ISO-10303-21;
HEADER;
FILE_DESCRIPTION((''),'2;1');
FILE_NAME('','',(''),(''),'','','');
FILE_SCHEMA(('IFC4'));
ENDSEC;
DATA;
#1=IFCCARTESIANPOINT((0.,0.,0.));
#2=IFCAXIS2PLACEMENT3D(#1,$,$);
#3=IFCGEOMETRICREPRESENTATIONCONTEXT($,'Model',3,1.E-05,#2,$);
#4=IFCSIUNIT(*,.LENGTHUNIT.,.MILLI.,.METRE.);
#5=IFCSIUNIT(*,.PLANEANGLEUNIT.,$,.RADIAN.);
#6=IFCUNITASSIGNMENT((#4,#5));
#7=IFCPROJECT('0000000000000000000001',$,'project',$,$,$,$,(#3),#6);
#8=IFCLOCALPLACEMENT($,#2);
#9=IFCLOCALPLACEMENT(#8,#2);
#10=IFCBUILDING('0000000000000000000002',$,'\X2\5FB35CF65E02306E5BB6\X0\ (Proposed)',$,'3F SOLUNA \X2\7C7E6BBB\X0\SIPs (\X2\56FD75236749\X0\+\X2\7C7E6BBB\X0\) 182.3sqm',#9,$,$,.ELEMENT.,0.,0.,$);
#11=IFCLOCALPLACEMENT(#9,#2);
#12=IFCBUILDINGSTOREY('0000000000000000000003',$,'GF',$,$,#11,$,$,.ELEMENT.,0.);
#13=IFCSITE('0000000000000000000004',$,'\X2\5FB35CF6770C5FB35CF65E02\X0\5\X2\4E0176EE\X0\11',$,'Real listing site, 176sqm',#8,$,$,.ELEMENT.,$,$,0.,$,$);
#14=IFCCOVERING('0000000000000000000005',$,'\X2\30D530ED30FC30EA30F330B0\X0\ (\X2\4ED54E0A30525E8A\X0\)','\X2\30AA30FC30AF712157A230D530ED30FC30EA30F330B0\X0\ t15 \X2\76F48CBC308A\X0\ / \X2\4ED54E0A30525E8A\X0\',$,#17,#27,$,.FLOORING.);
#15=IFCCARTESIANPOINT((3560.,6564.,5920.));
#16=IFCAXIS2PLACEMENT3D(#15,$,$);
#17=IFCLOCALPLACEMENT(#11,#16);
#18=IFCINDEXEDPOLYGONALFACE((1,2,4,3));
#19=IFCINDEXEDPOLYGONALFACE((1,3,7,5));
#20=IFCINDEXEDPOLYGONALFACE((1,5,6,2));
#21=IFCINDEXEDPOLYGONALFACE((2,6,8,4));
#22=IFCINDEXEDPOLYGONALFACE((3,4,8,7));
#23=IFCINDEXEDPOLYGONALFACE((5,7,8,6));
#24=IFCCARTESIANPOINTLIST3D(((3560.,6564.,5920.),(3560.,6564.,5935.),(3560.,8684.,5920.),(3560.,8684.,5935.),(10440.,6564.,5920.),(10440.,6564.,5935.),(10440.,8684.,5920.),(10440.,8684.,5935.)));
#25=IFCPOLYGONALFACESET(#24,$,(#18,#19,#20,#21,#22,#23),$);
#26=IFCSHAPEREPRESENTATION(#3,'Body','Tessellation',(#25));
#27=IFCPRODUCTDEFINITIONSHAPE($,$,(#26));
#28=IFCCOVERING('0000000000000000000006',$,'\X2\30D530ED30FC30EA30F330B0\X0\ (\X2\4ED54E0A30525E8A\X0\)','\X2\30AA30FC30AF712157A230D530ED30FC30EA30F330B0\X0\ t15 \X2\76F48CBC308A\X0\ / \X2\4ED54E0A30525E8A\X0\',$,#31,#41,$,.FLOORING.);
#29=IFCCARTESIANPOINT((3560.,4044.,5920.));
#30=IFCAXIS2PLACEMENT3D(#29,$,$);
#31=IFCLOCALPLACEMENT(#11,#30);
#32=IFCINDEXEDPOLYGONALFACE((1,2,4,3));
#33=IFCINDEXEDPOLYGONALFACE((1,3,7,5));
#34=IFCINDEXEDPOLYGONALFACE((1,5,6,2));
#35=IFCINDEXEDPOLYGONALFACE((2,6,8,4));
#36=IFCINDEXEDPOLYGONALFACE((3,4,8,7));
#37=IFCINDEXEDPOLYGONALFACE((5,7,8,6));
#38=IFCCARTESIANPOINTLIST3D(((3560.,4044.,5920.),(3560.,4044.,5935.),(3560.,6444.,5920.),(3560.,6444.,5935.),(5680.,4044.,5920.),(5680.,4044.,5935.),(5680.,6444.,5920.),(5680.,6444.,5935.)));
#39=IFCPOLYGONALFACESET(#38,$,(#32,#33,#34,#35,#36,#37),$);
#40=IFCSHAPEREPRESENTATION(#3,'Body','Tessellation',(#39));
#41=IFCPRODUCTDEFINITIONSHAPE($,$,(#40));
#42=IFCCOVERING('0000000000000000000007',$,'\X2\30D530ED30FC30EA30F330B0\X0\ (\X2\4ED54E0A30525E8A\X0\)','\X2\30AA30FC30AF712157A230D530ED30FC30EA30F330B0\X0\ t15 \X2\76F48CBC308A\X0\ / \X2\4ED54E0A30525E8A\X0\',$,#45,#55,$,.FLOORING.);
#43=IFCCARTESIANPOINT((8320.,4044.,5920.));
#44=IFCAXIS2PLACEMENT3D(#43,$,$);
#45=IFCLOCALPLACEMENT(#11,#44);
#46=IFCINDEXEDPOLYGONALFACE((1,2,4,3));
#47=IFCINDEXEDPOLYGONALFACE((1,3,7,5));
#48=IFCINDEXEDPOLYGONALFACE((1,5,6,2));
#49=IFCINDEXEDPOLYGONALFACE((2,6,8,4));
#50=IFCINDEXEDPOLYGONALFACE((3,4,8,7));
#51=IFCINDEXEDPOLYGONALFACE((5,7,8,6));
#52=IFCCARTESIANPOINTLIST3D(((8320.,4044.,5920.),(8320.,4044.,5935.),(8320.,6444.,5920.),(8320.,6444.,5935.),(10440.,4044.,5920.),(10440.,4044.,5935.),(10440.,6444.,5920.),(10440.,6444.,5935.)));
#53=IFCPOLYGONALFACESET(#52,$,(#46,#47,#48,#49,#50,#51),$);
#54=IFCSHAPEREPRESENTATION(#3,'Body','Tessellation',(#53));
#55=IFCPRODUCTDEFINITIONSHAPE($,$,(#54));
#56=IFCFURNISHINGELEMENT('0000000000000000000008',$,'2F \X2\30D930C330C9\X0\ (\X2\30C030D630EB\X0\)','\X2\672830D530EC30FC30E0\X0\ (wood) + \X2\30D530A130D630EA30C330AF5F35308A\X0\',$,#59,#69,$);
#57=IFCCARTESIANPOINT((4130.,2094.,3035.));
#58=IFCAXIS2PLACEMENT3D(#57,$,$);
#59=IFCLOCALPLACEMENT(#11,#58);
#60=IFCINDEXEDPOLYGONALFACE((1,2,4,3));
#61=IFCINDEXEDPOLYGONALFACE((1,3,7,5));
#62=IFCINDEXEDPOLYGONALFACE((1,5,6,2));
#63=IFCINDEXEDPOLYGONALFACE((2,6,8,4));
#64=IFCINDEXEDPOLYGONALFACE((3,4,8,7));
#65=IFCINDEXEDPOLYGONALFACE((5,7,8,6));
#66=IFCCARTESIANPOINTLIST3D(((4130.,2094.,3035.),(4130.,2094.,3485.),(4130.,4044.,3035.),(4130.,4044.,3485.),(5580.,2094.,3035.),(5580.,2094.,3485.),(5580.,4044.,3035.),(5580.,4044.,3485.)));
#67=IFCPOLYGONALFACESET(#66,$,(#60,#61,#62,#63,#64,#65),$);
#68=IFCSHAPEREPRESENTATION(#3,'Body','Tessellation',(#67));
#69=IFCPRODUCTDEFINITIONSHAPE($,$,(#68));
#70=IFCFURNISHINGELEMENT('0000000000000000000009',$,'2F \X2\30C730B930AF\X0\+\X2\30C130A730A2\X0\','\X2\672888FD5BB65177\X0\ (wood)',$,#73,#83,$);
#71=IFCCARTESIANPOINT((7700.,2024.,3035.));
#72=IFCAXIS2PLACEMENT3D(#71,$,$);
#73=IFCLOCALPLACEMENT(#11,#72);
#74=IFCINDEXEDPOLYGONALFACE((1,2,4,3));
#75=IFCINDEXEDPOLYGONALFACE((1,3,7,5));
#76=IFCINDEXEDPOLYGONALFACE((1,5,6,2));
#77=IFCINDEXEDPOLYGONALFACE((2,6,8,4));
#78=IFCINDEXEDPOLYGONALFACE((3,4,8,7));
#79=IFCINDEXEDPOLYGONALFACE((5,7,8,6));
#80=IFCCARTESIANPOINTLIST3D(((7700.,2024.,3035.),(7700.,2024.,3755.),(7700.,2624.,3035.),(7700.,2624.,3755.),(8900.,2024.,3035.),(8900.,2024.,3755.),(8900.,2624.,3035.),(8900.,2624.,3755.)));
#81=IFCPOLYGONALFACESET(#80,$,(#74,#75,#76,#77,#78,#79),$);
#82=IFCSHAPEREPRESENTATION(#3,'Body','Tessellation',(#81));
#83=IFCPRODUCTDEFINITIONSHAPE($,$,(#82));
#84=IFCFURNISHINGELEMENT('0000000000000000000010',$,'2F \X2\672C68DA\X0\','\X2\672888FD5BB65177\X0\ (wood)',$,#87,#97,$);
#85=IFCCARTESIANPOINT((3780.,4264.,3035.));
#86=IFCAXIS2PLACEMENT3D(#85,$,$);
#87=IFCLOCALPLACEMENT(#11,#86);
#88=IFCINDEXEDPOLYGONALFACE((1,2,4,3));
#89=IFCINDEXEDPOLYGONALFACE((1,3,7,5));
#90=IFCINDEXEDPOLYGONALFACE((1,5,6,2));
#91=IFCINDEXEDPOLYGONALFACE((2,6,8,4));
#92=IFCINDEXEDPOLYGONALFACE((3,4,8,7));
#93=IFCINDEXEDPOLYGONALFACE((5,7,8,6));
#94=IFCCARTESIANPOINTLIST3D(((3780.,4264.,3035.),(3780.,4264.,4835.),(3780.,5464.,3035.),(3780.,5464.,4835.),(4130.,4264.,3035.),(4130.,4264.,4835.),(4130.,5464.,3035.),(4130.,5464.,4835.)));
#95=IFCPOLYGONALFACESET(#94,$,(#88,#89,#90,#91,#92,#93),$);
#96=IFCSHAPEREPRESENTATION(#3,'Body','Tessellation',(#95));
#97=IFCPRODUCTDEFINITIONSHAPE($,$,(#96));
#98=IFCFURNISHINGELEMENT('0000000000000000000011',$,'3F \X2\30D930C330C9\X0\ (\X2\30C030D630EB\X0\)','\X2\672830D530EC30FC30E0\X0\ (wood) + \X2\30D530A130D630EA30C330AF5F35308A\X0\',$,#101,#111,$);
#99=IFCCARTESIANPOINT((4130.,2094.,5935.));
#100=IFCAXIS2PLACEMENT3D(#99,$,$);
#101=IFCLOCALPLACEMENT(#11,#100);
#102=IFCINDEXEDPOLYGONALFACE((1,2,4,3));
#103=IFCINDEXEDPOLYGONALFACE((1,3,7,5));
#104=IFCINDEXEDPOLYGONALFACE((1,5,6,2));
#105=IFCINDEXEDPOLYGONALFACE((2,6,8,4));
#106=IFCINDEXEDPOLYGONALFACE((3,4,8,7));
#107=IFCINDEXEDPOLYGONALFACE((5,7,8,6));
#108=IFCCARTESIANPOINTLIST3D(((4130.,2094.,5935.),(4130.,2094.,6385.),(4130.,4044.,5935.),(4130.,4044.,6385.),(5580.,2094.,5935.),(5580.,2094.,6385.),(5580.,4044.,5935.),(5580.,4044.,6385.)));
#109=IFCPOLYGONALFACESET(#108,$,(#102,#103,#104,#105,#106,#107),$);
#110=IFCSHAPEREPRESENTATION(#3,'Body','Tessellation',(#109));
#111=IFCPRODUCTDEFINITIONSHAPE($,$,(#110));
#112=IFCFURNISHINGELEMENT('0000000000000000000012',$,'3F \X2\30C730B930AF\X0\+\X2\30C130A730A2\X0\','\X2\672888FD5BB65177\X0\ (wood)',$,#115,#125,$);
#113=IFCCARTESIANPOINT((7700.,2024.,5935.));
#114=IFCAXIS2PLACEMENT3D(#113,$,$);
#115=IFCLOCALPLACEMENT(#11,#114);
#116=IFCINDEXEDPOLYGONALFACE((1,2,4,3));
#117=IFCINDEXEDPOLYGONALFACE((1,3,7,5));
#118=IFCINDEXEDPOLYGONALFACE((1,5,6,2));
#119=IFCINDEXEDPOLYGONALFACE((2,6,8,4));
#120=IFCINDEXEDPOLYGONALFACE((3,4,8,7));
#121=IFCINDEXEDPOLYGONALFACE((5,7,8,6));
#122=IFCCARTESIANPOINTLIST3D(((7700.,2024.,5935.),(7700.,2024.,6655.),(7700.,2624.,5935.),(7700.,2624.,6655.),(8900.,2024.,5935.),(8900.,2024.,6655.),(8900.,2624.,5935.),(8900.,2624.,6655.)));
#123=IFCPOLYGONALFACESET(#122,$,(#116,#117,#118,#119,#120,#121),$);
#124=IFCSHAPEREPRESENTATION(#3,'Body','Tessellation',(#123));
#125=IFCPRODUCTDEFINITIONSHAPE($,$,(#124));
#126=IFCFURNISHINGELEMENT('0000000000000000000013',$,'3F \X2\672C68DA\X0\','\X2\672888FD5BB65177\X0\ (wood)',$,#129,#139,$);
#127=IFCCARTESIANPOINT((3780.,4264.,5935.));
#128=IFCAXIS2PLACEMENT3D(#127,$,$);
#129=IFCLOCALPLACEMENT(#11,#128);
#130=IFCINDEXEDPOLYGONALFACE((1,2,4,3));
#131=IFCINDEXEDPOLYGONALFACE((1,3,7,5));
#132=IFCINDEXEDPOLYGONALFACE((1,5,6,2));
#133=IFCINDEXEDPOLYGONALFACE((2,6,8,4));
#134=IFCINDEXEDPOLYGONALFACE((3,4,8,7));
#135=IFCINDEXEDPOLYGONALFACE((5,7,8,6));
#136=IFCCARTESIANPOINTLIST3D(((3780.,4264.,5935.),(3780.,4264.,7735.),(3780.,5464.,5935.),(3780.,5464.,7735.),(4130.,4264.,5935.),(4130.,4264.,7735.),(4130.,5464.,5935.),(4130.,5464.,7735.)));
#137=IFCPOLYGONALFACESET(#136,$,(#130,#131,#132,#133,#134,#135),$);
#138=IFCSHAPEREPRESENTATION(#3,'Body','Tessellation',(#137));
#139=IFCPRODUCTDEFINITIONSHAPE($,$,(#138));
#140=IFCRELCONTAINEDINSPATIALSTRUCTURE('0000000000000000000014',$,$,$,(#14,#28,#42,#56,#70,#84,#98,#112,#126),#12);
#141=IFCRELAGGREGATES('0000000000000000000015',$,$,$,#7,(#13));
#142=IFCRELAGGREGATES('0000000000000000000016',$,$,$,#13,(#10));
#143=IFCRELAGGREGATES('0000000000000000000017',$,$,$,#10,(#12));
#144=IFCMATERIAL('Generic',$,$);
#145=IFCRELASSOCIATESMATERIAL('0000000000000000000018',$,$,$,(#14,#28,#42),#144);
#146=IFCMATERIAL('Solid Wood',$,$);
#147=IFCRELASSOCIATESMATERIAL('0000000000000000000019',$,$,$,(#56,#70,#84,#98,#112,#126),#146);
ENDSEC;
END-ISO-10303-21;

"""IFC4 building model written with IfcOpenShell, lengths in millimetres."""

from ifc_helpers import new_model, si_unit, frame, frame_2d, origin, place, context, project, spatial, rectangle, extrude, material, element, save


model = new_model("IFC4")

# Units and contexts
model_context = context("Model", 3, precision=1e-05, world=origin())
ifc_project = project(units=[si_unit("LENGTHUNIT", "METRE", prefix="MILLI"), si_unit("PLANEANGLEUNIT", "RADIAN")], contexts=[model_context])

# Site, building, storey
site_placement = place(None, origin())
site = spatial("IfcSite", under=ifc_project, at=site_placement, Name="徳島県徳島市5丁目11", ObjectType="Real listing site, 176sqm", CompositionType="ELEMENT", RefElevation=0.0)
building_placement = place(site_placement, origin())
building = spatial("IfcBuilding", under=site, at=building_placement, Name="徳島市の家 (Proposed)", ObjectType="3F SOLUNA 籾殻SIPs (国産杉+籾殻) 182.3sqm", CompositionType="ELEMENT", ElevationOfRefHeight=0.0, ElevationOfTerrain=0.0)
storey_placement = place(building_placement, origin())
storey = spatial("IfcBuildingStorey", under=building, at=storey_placement, Name="GF", CompositionType="ELEMENT", Elevation=0.0)

# Shared definitions
ifc_material_1 = material(Name="Solid Wood")

# Shared definitions
ifc_material_2 = material(Name="Generic")

# Coverings
covering_1_placement = place(storey_placement, frame((3560.0, 6564.0, 5920.0)))
element("IfcCovering", 1, at=covering_1_placement, inside=storey, material=ifc_material_2, Name="フローリング (仕上げ床)", Description="オーク無垢フローリング t15 直貼り / 仕上げ床", PredefinedType="FLOORING", context=model_context, shape_type="SweptSolid", body=[
    extrude(rectangle(XDim=6880.0, YDim=2120.0, at=frame_2d((3440.0, 1060.0))), frame((3560.0, 6564.0, 5920.0)), (0.0, 0.0, 1.0), 15.0),
])
covering_2_placement = place(storey_placement, frame((3560.0, 4044.0, 5920.0)))
element("IfcCovering", 2, at=covering_2_placement, inside=storey, material=ifc_material_2, Name="フローリング (仕上げ床)", Description="オーク無垢フローリング t15 直貼り / 仕上げ床", PredefinedType="FLOORING", context=model_context, shape_type="SweptSolid", body=[
    extrude(rectangle(XDim=2120.0, YDim=2400.0, at=frame_2d((1060.0, 1200.0))), frame((3560.0, 4044.0, 5920.0)), (0.0, 0.0, 1.0), 15.0),
])
covering_3_placement = place(storey_placement, frame((8320.0, 4044.0, 5920.0)))
element("IfcCovering", 3, at=covering_3_placement, inside=storey, material=ifc_material_2, Name="フローリング (仕上げ床)", Description="オーク無垢フローリング t15 直貼り / 仕上げ床", PredefinedType="FLOORING", context=model_context, shape_type="SweptSolid", body=[
    extrude(rectangle(XDim=2120.0, YDim=2400.0, at=frame_2d((1060.0, 1200.0))), frame((8320.0, 4044.0, 5920.0)), (0.0, 0.0, 1.0), 15.0),
])

# Furnishing elements
furnishing_1_placement = place(storey_placement, frame((4130.0, 2094.0, 3035.0)))
element("IfcFurnishingElement", 4, at=furnishing_1_placement, inside=storey, material=ifc_material_1, Name="2F ベッド (ダブル)", Description="木フレーム (wood) + ファブリック張り", context=model_context, shape_type="SweptSolid", body=[
    extrude(rectangle(XDim=1450.0, YDim=1950.0, at=frame_2d((725.0, 975.0))), frame((4130.0, 2094.0, 3035.0)), (0.0, 0.0, 1.0), 450.0),
])
furnishing_2_placement = place(storey_placement, frame((7700.0, 2024.0, 3035.0)))
element("IfcFurnishingElement", 5, at=furnishing_2_placement, inside=storey, material=ifc_material_1, Name="2F デスク+チェア", Description="木製家具 (wood)", context=model_context, shape_type="SweptSolid", body=[
    extrude(rectangle(XDim=1200.0, YDim=600.0, at=frame_2d((600.0, 300.0))), frame((7700.0, 2024.0, 3035.0)), (0.0, 0.0, 1.0), 720.0),
])
furnishing_3_placement = place(storey_placement, frame((3780.0, 4264.0, 3035.0)))
element("IfcFurnishingElement", 6, at=furnishing_3_placement, inside=storey, material=ifc_material_1, Name="2F 本棚", Description="木製家具 (wood)", context=model_context, shape_type="SweptSolid", body=[
    extrude(rectangle(XDim=350.0, YDim=1200.0, at=frame_2d((175.0, 600.0))), frame((3780.0, 4264.0, 3035.0)), (0.0, 0.0, 1.0), 1800.0),
])
furnishing_4_placement = place(storey_placement, frame((4130.0, 2094.0, 5935.0)))
element("IfcFurnishingElement", 7, at=furnishing_4_placement, inside=storey, material=ifc_material_1, Name="3F ベッド (ダブル)", Description="木フレーム (wood) + ファブリック張り", context=model_context, shape_type="SweptSolid", body=[
    extrude(rectangle(XDim=1450.0, YDim=1950.0, at=frame_2d((725.0, 975.0))), frame((4130.0, 2094.0, 5935.0)), (0.0, 0.0, 1.0), 450.0),
])
furnishing_5_placement = place(storey_placement, frame((7700.0, 2024.0, 5935.0)))
element("IfcFurnishingElement", 8, at=furnishing_5_placement, inside=storey, material=ifc_material_1, Name="3F デスク+チェア", Description="木製家具 (wood)", context=model_context, shape_type="SweptSolid", body=[
    extrude(rectangle(XDim=1200.0, YDim=600.0, at=frame_2d((600.0, 300.0))), frame((7700.0, 2024.0, 5935.0)), (0.0, 0.0, 1.0), 720.0),
])
furnishing_6_placement = place(storey_placement, frame((3780.0, 4264.0, 5935.0)))
element("IfcFurnishingElement", 9, at=furnishing_6_placement, inside=storey, material=ifc_material_1, Name="3F 本棚", Description="木製家具 (wood)", context=model_context, shape_type="SweptSolid", body=[
    extrude(rectangle(XDim=350.0, YDim=1200.0, at=frame_2d((175.0, 600.0))), frame((3780.0, 4264.0, 5935.0)), (0.0, 0.0, 1.0), 1800.0),
])

save(model, "model.ifc")
